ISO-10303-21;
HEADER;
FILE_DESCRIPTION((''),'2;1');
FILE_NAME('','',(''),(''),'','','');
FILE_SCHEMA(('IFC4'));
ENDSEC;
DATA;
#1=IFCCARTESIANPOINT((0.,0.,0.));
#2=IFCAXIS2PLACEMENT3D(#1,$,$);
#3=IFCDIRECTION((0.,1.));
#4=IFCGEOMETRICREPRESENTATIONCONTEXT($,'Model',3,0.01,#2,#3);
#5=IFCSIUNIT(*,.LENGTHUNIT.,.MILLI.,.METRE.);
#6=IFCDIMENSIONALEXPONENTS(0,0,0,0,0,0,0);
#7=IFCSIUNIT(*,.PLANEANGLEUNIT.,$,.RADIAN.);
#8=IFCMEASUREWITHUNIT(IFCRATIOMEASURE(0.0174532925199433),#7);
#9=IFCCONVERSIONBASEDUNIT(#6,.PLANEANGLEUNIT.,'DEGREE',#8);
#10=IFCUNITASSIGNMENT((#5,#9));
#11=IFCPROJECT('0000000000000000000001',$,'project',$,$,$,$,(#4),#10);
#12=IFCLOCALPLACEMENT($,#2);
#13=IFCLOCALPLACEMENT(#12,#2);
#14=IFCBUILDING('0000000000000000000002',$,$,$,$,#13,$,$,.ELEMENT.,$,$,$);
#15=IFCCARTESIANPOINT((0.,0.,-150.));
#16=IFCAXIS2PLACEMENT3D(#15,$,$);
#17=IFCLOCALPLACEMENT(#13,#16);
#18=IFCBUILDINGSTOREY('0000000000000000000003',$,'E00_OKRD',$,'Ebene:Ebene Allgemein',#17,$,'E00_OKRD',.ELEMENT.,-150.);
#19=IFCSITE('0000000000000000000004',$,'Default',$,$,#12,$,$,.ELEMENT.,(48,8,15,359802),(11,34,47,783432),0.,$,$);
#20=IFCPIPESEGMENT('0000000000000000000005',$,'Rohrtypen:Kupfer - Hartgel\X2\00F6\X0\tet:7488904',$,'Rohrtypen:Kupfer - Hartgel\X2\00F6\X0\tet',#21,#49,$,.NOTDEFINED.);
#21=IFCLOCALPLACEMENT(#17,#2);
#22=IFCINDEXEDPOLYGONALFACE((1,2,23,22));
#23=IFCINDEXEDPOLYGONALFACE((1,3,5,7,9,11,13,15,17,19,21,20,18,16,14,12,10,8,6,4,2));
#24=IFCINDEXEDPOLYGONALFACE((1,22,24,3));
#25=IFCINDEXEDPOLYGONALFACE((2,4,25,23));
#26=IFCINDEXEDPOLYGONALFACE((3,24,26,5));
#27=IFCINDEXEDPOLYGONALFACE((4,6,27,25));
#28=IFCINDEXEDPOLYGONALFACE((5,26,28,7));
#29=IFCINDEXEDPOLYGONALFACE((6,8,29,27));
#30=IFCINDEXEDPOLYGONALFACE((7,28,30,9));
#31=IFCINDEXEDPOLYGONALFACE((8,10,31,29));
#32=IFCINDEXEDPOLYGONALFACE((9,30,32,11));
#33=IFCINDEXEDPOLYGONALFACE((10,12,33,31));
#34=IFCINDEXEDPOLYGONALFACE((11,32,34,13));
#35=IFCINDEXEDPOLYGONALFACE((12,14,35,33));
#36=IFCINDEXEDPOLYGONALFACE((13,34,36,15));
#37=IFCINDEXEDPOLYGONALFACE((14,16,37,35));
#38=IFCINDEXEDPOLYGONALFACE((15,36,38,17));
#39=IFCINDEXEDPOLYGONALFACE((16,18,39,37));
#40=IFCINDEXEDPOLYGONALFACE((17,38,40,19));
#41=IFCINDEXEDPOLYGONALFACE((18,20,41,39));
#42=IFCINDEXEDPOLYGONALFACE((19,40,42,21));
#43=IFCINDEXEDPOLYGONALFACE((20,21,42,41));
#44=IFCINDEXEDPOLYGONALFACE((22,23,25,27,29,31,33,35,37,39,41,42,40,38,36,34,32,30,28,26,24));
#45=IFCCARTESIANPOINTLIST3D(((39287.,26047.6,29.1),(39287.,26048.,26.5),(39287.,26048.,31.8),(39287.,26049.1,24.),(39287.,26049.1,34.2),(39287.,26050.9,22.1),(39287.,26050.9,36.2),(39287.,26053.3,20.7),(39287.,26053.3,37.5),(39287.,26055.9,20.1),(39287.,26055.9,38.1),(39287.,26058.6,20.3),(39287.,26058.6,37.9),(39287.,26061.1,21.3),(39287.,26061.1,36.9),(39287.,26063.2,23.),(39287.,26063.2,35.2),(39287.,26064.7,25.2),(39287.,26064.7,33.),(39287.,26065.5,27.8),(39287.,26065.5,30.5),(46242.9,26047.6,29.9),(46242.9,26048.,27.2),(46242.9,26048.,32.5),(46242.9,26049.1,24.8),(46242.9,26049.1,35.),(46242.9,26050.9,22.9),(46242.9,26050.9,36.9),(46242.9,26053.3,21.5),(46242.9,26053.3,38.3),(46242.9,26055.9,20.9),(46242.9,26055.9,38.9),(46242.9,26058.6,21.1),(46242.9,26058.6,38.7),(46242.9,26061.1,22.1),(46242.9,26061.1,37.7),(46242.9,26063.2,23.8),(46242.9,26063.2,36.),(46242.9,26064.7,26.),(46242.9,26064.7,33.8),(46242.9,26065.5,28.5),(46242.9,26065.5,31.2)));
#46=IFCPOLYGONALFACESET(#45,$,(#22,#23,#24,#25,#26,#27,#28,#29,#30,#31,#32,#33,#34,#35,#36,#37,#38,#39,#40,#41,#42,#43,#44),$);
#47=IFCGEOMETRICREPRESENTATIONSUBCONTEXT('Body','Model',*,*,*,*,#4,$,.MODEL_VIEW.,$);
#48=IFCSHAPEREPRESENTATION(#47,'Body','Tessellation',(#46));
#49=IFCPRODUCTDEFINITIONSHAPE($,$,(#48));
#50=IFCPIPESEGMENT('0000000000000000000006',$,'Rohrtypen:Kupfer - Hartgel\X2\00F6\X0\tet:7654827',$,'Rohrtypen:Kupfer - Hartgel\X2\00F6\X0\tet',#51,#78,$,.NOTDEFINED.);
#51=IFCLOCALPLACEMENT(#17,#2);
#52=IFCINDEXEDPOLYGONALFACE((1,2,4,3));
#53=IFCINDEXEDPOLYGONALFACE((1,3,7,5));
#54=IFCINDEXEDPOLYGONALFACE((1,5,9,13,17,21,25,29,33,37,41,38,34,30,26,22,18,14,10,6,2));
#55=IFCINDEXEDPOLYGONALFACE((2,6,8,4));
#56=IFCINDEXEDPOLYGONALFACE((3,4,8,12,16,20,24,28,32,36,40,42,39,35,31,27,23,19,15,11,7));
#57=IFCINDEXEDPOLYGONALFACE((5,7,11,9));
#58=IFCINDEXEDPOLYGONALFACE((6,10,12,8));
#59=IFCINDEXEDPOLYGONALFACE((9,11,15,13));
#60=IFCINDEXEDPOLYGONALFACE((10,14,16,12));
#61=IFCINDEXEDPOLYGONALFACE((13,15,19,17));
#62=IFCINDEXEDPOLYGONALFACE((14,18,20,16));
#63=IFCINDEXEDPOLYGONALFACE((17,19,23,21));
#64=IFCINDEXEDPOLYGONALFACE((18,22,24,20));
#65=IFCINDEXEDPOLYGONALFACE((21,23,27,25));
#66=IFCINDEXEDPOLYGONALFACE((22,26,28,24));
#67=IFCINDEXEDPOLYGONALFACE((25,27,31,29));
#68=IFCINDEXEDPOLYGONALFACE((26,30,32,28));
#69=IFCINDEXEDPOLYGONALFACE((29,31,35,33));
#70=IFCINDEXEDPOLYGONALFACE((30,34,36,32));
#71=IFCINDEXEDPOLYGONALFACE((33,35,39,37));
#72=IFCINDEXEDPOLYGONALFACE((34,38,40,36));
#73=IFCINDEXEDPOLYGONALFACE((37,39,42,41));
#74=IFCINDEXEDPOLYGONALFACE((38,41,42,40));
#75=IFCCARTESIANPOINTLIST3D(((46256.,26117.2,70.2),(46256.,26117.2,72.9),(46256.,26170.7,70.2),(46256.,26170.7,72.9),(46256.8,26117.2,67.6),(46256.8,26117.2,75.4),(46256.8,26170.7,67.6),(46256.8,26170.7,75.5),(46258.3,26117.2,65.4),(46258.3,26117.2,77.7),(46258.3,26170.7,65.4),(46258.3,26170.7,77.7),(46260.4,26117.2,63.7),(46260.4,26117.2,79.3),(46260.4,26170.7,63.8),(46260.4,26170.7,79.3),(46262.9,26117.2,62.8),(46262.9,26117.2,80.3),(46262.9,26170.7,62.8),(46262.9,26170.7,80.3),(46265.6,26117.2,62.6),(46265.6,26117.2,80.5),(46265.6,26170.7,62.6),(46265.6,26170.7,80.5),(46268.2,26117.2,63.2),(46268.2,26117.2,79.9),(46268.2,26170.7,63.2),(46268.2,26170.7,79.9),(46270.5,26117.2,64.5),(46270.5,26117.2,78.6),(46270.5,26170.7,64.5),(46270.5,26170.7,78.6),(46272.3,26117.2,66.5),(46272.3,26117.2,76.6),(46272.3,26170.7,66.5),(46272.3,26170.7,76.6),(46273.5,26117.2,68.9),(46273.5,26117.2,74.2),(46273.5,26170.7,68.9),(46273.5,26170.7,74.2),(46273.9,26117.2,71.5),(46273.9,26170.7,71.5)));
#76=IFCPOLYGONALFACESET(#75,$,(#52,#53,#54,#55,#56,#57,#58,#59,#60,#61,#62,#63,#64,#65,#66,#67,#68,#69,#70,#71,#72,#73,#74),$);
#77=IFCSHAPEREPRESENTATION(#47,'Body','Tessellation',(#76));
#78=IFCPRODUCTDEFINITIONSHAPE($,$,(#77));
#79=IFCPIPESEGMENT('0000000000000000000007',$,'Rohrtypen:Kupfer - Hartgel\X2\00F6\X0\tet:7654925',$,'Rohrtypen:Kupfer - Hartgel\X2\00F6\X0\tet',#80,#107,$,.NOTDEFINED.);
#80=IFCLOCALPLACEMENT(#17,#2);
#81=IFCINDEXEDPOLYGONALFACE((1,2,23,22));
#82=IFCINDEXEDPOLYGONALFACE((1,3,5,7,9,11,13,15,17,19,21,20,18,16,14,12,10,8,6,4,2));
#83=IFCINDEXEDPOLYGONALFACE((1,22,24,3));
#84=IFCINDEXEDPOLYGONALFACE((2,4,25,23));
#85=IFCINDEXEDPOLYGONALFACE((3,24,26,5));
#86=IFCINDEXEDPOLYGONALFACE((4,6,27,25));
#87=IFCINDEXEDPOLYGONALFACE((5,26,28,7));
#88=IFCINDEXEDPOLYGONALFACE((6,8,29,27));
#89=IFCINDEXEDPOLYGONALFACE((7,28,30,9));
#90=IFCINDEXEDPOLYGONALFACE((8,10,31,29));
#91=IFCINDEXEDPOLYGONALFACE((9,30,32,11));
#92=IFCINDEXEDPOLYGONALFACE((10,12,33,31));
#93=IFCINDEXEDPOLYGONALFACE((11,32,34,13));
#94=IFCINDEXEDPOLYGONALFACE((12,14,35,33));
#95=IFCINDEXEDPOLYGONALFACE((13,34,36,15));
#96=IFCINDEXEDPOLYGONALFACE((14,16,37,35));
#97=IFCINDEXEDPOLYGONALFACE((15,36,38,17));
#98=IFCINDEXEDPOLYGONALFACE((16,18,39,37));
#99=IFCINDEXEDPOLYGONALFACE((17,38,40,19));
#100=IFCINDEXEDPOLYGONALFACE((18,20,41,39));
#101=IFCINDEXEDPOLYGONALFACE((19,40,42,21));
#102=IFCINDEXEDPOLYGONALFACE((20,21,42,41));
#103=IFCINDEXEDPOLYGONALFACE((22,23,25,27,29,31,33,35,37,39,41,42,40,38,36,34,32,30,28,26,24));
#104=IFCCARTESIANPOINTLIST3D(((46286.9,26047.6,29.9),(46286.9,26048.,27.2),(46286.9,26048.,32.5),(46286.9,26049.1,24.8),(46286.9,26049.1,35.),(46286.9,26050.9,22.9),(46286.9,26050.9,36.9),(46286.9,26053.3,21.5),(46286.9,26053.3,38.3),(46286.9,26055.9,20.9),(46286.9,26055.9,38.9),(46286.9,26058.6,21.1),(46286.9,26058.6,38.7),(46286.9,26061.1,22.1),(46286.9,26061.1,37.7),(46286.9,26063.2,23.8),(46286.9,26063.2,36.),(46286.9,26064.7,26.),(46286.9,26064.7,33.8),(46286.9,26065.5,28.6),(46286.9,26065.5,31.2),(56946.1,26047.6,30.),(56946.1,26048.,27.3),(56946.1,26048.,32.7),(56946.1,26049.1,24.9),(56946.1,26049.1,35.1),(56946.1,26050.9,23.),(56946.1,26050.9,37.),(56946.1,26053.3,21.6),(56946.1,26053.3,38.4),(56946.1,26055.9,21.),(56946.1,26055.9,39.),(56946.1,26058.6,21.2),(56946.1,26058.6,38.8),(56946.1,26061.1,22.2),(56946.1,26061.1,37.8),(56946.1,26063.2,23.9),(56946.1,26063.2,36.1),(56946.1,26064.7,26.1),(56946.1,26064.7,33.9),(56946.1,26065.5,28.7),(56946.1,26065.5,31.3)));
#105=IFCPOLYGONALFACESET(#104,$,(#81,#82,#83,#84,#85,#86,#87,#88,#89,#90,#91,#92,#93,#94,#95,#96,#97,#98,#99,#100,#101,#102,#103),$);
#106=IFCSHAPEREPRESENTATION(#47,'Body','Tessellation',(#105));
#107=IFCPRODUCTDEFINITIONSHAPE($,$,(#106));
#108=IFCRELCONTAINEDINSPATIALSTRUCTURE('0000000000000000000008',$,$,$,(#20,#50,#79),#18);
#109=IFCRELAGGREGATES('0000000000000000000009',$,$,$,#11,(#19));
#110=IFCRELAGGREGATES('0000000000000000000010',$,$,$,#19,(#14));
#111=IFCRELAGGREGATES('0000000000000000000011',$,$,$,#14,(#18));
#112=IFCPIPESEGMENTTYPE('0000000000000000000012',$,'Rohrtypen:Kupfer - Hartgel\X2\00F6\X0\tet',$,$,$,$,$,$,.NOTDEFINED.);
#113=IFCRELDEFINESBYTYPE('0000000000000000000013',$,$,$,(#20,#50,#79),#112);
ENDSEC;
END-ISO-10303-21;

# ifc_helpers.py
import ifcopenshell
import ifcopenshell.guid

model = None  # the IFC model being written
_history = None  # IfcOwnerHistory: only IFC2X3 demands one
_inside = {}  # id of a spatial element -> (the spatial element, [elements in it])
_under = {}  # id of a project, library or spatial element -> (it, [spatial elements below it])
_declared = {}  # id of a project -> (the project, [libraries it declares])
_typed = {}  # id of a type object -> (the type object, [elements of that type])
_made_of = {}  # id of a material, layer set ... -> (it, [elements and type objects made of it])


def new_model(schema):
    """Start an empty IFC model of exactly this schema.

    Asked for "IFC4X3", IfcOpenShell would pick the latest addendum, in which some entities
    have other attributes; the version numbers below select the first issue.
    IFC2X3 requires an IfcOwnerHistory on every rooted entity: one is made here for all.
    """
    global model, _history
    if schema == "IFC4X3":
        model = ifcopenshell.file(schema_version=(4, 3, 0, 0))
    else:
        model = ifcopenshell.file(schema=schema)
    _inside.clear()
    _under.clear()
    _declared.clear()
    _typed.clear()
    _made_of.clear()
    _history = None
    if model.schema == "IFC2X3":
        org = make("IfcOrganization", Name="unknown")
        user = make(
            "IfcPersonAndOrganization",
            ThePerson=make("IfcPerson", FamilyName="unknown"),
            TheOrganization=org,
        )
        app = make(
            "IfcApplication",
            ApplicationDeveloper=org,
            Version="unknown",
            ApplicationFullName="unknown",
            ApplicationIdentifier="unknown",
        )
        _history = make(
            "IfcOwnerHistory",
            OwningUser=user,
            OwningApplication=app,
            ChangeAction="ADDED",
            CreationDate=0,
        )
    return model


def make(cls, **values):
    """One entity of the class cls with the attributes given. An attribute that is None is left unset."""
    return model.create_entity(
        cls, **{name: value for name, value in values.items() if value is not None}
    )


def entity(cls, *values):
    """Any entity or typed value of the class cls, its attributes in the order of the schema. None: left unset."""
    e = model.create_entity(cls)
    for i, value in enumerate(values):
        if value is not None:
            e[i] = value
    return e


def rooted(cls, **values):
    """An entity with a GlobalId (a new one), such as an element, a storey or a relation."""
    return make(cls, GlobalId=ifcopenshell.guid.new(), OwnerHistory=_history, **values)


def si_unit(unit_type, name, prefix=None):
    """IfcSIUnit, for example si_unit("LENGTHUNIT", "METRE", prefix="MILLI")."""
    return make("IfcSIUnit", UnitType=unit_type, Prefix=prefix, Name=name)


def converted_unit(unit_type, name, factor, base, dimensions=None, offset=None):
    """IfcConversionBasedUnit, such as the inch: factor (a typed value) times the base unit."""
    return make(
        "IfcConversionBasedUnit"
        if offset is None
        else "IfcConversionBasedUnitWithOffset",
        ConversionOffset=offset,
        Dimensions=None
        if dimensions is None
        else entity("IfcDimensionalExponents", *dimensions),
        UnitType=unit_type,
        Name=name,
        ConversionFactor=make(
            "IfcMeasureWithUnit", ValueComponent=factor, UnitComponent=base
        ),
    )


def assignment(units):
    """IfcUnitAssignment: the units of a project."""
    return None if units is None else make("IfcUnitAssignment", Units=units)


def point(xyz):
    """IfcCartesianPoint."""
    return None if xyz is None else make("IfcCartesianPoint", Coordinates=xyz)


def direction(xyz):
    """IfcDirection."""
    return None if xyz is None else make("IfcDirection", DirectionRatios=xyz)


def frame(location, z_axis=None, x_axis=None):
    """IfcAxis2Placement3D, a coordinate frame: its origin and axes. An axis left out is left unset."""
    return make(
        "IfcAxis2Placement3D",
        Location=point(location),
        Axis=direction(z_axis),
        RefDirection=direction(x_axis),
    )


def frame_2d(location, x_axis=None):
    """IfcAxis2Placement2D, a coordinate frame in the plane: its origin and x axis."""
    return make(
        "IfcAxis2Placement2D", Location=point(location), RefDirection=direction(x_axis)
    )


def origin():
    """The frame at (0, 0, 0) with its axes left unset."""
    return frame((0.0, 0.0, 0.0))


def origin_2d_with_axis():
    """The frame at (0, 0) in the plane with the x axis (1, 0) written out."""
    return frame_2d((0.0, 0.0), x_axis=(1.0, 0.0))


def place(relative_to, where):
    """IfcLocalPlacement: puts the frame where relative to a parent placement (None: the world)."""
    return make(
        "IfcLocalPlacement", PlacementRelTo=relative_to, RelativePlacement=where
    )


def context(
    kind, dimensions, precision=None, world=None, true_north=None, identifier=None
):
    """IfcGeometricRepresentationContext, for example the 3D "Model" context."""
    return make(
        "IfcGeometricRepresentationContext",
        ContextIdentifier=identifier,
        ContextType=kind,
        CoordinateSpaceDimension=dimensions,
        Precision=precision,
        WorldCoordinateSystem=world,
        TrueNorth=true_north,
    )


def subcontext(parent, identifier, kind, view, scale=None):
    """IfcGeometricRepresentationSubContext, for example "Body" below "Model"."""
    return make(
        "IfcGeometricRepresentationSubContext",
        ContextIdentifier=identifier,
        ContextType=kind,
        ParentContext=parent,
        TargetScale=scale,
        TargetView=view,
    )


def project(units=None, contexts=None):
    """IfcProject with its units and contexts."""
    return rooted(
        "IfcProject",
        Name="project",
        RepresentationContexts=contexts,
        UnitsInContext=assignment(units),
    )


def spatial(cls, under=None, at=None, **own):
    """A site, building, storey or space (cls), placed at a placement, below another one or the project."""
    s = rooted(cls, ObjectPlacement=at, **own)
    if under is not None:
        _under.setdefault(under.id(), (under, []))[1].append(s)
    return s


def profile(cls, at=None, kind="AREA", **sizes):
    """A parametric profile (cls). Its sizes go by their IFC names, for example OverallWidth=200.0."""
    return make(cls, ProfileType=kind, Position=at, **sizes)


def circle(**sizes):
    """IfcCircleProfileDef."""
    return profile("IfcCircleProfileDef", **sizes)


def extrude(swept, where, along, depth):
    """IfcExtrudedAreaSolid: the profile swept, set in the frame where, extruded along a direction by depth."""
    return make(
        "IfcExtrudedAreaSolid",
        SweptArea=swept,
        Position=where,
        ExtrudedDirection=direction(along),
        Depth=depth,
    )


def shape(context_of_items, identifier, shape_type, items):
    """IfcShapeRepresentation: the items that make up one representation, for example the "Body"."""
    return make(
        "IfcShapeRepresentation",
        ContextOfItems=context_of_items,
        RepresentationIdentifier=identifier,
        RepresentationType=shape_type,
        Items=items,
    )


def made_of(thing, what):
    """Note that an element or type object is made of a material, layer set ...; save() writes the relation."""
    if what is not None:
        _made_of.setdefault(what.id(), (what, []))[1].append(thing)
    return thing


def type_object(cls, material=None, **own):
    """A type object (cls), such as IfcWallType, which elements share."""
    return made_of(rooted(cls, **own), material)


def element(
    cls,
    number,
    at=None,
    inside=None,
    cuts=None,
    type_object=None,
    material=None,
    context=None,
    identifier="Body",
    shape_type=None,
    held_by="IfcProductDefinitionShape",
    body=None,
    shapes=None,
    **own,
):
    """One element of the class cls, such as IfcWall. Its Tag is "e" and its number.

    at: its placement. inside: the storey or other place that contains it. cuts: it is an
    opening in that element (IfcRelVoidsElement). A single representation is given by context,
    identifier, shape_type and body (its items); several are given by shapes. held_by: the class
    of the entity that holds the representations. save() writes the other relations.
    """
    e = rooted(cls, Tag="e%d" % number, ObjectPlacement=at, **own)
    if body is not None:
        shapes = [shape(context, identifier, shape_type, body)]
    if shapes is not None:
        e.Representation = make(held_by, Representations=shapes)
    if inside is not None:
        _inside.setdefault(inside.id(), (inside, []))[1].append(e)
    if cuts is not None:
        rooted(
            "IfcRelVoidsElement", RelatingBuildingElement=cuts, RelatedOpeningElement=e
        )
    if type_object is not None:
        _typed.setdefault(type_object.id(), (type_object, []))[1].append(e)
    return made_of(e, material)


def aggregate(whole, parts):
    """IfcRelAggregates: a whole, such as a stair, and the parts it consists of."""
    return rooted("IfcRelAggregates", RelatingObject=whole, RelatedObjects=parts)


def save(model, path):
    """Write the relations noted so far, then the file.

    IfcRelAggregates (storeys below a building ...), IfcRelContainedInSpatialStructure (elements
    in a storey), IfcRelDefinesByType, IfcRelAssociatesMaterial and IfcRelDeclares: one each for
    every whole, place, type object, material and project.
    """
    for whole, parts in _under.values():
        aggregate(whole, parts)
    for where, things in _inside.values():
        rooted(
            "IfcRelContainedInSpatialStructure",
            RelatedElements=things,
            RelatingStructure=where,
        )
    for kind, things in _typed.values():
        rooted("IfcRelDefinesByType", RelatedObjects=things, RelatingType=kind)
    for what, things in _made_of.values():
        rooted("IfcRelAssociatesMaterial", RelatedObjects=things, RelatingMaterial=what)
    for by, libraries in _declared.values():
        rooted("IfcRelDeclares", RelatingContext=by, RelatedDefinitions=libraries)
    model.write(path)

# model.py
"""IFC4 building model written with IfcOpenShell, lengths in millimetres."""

from ifc_helpers import new_model, entity, si_unit, converted_unit, direction, frame, frame_2d, origin, origin_2d_with_axis, place, context, subcontext, project, spatial, circle, extrude, type_object, element, save


model = new_model("IFC4")

# Units and contexts
model_context = context("Model", 3, precision=0.01, world=origin(), true_north=direction((0.0, 1.0)))
body_context = subcontext(model_context, "Body", "Model", "MODEL_VIEW")
ifc_project = project(units=[si_unit("LENGTHUNIT", "METRE", prefix="MILLI"), converted_unit("PLANEANGLEUNIT", "DEGREE", entity("IfcRatioMeasure", 0.0174532925199433), si_unit("PLANEANGLEUNIT", "RADIAN"), dimensions=[0, 0, 0, 0, 0, 0, 0])], contexts=[model_context])

# Site, building, storey
site_placement = place(None, origin())
site = spatial("IfcSite", under=ifc_project, at=site_placement, Name="Default", CompositionType="ELEMENT", RefLatitude=(48, 8, 15, 359802), RefLongitude=(11, 34, 47, 783432), RefElevation=0.0)
building_placement = place(site_placement, origin())
building = spatial("IfcBuilding", under=site, at=building_placement, CompositionType="ELEMENT")
storey_placement = place(building_placement, frame((0.0, 0.0, -150.0)))
storey = spatial("IfcBuildingStorey", under=building, at=storey_placement, Name="E00_OKRD", ObjectType="Ebene:Ebene Allgemein", LongName="E00_OKRD", CompositionType="ELEMENT", Elevation=-150.0)

# Pipe segments
pipe_segment_type = type_object("IfcPipeSegmentType", Name="Rohrtypen:Kupfer - Hartgelötet", PredefinedType="NOTDEFINED")
pipe_segment_1_placement = place(storey_placement, frame((39287.0, 26046.0, 18.5)))
element("IfcPipeSegment", 1, at=pipe_segment_1_placement, inside=storey, type_object=pipe_segment_type, Name="Rohrtypen:Kupfer - Hartgelötet:7488904", ObjectType="Rohrtypen:Kupfer - Hartgelötet", PredefinedType="NOTDEFINED", context=body_context, shape_type="SweptSolid", body=[
    extrude(circle(Radius=9.0, at=frame_2d((0.0, 0.0), x_axis=(1.0, 0.0))), frame((0.0, 10.6, 10.6), z_axis=(1.0, 0.0, 0.000111), x_axis=(0.0, -1.0, 0.0)), (0.0, 0.0, 1.0), 6956.0),
])
pipe_segment_2_placement = place(storey_placement, frame((46254.3, 26117.2, 60.9)))
element("IfcPipeSegment", 2, at=pipe_segment_2_placement, inside=storey, type_object=pipe_segment_type, Name="Rohrtypen:Kupfer - Hartgelötet:7654827", ObjectType="Rohrtypen:Kupfer - Hartgelötet", PredefinedType="NOTDEFINED", context=body_context, shape_type="SweptSolid", body=[
    extrude(circle(Radius=9.0, at=origin_2d_with_axis()), frame((10.6, 0.0, 10.6), z_axis=(0.0, 1.0, 0.000282), x_axis=(1.0, 0.0, 0.0)), (0.0, 0.0, 1.0), 53.5),
])
pipe_segment_3_placement = place(storey_placement, frame((46286.9, 26046.0, 19.3)))
element("IfcPipeSegment", 3, at=pipe_segment_3_placement, inside=storey, type_object=pipe_segment_type, Name="Rohrtypen:Kupfer - Hartgelötet:7654925", ObjectType="Rohrtypen:Kupfer - Hartgelötet", PredefinedType="NOTDEFINED", context=body_context, shape_type="SweptSolid", body=[
    extrude(circle(Radius=9.0, at=frame_2d((0.0, 0.0), x_axis=(1.0, 0.0))), frame((0.0, 10.6, 10.6), z_axis=(1.0, 0.0, 0.00001), x_axis=(0.0, -1.0, 0.0)), (0.0, 0.0, 1.0), 10659.2),
])

save(model, "model.ifc")
